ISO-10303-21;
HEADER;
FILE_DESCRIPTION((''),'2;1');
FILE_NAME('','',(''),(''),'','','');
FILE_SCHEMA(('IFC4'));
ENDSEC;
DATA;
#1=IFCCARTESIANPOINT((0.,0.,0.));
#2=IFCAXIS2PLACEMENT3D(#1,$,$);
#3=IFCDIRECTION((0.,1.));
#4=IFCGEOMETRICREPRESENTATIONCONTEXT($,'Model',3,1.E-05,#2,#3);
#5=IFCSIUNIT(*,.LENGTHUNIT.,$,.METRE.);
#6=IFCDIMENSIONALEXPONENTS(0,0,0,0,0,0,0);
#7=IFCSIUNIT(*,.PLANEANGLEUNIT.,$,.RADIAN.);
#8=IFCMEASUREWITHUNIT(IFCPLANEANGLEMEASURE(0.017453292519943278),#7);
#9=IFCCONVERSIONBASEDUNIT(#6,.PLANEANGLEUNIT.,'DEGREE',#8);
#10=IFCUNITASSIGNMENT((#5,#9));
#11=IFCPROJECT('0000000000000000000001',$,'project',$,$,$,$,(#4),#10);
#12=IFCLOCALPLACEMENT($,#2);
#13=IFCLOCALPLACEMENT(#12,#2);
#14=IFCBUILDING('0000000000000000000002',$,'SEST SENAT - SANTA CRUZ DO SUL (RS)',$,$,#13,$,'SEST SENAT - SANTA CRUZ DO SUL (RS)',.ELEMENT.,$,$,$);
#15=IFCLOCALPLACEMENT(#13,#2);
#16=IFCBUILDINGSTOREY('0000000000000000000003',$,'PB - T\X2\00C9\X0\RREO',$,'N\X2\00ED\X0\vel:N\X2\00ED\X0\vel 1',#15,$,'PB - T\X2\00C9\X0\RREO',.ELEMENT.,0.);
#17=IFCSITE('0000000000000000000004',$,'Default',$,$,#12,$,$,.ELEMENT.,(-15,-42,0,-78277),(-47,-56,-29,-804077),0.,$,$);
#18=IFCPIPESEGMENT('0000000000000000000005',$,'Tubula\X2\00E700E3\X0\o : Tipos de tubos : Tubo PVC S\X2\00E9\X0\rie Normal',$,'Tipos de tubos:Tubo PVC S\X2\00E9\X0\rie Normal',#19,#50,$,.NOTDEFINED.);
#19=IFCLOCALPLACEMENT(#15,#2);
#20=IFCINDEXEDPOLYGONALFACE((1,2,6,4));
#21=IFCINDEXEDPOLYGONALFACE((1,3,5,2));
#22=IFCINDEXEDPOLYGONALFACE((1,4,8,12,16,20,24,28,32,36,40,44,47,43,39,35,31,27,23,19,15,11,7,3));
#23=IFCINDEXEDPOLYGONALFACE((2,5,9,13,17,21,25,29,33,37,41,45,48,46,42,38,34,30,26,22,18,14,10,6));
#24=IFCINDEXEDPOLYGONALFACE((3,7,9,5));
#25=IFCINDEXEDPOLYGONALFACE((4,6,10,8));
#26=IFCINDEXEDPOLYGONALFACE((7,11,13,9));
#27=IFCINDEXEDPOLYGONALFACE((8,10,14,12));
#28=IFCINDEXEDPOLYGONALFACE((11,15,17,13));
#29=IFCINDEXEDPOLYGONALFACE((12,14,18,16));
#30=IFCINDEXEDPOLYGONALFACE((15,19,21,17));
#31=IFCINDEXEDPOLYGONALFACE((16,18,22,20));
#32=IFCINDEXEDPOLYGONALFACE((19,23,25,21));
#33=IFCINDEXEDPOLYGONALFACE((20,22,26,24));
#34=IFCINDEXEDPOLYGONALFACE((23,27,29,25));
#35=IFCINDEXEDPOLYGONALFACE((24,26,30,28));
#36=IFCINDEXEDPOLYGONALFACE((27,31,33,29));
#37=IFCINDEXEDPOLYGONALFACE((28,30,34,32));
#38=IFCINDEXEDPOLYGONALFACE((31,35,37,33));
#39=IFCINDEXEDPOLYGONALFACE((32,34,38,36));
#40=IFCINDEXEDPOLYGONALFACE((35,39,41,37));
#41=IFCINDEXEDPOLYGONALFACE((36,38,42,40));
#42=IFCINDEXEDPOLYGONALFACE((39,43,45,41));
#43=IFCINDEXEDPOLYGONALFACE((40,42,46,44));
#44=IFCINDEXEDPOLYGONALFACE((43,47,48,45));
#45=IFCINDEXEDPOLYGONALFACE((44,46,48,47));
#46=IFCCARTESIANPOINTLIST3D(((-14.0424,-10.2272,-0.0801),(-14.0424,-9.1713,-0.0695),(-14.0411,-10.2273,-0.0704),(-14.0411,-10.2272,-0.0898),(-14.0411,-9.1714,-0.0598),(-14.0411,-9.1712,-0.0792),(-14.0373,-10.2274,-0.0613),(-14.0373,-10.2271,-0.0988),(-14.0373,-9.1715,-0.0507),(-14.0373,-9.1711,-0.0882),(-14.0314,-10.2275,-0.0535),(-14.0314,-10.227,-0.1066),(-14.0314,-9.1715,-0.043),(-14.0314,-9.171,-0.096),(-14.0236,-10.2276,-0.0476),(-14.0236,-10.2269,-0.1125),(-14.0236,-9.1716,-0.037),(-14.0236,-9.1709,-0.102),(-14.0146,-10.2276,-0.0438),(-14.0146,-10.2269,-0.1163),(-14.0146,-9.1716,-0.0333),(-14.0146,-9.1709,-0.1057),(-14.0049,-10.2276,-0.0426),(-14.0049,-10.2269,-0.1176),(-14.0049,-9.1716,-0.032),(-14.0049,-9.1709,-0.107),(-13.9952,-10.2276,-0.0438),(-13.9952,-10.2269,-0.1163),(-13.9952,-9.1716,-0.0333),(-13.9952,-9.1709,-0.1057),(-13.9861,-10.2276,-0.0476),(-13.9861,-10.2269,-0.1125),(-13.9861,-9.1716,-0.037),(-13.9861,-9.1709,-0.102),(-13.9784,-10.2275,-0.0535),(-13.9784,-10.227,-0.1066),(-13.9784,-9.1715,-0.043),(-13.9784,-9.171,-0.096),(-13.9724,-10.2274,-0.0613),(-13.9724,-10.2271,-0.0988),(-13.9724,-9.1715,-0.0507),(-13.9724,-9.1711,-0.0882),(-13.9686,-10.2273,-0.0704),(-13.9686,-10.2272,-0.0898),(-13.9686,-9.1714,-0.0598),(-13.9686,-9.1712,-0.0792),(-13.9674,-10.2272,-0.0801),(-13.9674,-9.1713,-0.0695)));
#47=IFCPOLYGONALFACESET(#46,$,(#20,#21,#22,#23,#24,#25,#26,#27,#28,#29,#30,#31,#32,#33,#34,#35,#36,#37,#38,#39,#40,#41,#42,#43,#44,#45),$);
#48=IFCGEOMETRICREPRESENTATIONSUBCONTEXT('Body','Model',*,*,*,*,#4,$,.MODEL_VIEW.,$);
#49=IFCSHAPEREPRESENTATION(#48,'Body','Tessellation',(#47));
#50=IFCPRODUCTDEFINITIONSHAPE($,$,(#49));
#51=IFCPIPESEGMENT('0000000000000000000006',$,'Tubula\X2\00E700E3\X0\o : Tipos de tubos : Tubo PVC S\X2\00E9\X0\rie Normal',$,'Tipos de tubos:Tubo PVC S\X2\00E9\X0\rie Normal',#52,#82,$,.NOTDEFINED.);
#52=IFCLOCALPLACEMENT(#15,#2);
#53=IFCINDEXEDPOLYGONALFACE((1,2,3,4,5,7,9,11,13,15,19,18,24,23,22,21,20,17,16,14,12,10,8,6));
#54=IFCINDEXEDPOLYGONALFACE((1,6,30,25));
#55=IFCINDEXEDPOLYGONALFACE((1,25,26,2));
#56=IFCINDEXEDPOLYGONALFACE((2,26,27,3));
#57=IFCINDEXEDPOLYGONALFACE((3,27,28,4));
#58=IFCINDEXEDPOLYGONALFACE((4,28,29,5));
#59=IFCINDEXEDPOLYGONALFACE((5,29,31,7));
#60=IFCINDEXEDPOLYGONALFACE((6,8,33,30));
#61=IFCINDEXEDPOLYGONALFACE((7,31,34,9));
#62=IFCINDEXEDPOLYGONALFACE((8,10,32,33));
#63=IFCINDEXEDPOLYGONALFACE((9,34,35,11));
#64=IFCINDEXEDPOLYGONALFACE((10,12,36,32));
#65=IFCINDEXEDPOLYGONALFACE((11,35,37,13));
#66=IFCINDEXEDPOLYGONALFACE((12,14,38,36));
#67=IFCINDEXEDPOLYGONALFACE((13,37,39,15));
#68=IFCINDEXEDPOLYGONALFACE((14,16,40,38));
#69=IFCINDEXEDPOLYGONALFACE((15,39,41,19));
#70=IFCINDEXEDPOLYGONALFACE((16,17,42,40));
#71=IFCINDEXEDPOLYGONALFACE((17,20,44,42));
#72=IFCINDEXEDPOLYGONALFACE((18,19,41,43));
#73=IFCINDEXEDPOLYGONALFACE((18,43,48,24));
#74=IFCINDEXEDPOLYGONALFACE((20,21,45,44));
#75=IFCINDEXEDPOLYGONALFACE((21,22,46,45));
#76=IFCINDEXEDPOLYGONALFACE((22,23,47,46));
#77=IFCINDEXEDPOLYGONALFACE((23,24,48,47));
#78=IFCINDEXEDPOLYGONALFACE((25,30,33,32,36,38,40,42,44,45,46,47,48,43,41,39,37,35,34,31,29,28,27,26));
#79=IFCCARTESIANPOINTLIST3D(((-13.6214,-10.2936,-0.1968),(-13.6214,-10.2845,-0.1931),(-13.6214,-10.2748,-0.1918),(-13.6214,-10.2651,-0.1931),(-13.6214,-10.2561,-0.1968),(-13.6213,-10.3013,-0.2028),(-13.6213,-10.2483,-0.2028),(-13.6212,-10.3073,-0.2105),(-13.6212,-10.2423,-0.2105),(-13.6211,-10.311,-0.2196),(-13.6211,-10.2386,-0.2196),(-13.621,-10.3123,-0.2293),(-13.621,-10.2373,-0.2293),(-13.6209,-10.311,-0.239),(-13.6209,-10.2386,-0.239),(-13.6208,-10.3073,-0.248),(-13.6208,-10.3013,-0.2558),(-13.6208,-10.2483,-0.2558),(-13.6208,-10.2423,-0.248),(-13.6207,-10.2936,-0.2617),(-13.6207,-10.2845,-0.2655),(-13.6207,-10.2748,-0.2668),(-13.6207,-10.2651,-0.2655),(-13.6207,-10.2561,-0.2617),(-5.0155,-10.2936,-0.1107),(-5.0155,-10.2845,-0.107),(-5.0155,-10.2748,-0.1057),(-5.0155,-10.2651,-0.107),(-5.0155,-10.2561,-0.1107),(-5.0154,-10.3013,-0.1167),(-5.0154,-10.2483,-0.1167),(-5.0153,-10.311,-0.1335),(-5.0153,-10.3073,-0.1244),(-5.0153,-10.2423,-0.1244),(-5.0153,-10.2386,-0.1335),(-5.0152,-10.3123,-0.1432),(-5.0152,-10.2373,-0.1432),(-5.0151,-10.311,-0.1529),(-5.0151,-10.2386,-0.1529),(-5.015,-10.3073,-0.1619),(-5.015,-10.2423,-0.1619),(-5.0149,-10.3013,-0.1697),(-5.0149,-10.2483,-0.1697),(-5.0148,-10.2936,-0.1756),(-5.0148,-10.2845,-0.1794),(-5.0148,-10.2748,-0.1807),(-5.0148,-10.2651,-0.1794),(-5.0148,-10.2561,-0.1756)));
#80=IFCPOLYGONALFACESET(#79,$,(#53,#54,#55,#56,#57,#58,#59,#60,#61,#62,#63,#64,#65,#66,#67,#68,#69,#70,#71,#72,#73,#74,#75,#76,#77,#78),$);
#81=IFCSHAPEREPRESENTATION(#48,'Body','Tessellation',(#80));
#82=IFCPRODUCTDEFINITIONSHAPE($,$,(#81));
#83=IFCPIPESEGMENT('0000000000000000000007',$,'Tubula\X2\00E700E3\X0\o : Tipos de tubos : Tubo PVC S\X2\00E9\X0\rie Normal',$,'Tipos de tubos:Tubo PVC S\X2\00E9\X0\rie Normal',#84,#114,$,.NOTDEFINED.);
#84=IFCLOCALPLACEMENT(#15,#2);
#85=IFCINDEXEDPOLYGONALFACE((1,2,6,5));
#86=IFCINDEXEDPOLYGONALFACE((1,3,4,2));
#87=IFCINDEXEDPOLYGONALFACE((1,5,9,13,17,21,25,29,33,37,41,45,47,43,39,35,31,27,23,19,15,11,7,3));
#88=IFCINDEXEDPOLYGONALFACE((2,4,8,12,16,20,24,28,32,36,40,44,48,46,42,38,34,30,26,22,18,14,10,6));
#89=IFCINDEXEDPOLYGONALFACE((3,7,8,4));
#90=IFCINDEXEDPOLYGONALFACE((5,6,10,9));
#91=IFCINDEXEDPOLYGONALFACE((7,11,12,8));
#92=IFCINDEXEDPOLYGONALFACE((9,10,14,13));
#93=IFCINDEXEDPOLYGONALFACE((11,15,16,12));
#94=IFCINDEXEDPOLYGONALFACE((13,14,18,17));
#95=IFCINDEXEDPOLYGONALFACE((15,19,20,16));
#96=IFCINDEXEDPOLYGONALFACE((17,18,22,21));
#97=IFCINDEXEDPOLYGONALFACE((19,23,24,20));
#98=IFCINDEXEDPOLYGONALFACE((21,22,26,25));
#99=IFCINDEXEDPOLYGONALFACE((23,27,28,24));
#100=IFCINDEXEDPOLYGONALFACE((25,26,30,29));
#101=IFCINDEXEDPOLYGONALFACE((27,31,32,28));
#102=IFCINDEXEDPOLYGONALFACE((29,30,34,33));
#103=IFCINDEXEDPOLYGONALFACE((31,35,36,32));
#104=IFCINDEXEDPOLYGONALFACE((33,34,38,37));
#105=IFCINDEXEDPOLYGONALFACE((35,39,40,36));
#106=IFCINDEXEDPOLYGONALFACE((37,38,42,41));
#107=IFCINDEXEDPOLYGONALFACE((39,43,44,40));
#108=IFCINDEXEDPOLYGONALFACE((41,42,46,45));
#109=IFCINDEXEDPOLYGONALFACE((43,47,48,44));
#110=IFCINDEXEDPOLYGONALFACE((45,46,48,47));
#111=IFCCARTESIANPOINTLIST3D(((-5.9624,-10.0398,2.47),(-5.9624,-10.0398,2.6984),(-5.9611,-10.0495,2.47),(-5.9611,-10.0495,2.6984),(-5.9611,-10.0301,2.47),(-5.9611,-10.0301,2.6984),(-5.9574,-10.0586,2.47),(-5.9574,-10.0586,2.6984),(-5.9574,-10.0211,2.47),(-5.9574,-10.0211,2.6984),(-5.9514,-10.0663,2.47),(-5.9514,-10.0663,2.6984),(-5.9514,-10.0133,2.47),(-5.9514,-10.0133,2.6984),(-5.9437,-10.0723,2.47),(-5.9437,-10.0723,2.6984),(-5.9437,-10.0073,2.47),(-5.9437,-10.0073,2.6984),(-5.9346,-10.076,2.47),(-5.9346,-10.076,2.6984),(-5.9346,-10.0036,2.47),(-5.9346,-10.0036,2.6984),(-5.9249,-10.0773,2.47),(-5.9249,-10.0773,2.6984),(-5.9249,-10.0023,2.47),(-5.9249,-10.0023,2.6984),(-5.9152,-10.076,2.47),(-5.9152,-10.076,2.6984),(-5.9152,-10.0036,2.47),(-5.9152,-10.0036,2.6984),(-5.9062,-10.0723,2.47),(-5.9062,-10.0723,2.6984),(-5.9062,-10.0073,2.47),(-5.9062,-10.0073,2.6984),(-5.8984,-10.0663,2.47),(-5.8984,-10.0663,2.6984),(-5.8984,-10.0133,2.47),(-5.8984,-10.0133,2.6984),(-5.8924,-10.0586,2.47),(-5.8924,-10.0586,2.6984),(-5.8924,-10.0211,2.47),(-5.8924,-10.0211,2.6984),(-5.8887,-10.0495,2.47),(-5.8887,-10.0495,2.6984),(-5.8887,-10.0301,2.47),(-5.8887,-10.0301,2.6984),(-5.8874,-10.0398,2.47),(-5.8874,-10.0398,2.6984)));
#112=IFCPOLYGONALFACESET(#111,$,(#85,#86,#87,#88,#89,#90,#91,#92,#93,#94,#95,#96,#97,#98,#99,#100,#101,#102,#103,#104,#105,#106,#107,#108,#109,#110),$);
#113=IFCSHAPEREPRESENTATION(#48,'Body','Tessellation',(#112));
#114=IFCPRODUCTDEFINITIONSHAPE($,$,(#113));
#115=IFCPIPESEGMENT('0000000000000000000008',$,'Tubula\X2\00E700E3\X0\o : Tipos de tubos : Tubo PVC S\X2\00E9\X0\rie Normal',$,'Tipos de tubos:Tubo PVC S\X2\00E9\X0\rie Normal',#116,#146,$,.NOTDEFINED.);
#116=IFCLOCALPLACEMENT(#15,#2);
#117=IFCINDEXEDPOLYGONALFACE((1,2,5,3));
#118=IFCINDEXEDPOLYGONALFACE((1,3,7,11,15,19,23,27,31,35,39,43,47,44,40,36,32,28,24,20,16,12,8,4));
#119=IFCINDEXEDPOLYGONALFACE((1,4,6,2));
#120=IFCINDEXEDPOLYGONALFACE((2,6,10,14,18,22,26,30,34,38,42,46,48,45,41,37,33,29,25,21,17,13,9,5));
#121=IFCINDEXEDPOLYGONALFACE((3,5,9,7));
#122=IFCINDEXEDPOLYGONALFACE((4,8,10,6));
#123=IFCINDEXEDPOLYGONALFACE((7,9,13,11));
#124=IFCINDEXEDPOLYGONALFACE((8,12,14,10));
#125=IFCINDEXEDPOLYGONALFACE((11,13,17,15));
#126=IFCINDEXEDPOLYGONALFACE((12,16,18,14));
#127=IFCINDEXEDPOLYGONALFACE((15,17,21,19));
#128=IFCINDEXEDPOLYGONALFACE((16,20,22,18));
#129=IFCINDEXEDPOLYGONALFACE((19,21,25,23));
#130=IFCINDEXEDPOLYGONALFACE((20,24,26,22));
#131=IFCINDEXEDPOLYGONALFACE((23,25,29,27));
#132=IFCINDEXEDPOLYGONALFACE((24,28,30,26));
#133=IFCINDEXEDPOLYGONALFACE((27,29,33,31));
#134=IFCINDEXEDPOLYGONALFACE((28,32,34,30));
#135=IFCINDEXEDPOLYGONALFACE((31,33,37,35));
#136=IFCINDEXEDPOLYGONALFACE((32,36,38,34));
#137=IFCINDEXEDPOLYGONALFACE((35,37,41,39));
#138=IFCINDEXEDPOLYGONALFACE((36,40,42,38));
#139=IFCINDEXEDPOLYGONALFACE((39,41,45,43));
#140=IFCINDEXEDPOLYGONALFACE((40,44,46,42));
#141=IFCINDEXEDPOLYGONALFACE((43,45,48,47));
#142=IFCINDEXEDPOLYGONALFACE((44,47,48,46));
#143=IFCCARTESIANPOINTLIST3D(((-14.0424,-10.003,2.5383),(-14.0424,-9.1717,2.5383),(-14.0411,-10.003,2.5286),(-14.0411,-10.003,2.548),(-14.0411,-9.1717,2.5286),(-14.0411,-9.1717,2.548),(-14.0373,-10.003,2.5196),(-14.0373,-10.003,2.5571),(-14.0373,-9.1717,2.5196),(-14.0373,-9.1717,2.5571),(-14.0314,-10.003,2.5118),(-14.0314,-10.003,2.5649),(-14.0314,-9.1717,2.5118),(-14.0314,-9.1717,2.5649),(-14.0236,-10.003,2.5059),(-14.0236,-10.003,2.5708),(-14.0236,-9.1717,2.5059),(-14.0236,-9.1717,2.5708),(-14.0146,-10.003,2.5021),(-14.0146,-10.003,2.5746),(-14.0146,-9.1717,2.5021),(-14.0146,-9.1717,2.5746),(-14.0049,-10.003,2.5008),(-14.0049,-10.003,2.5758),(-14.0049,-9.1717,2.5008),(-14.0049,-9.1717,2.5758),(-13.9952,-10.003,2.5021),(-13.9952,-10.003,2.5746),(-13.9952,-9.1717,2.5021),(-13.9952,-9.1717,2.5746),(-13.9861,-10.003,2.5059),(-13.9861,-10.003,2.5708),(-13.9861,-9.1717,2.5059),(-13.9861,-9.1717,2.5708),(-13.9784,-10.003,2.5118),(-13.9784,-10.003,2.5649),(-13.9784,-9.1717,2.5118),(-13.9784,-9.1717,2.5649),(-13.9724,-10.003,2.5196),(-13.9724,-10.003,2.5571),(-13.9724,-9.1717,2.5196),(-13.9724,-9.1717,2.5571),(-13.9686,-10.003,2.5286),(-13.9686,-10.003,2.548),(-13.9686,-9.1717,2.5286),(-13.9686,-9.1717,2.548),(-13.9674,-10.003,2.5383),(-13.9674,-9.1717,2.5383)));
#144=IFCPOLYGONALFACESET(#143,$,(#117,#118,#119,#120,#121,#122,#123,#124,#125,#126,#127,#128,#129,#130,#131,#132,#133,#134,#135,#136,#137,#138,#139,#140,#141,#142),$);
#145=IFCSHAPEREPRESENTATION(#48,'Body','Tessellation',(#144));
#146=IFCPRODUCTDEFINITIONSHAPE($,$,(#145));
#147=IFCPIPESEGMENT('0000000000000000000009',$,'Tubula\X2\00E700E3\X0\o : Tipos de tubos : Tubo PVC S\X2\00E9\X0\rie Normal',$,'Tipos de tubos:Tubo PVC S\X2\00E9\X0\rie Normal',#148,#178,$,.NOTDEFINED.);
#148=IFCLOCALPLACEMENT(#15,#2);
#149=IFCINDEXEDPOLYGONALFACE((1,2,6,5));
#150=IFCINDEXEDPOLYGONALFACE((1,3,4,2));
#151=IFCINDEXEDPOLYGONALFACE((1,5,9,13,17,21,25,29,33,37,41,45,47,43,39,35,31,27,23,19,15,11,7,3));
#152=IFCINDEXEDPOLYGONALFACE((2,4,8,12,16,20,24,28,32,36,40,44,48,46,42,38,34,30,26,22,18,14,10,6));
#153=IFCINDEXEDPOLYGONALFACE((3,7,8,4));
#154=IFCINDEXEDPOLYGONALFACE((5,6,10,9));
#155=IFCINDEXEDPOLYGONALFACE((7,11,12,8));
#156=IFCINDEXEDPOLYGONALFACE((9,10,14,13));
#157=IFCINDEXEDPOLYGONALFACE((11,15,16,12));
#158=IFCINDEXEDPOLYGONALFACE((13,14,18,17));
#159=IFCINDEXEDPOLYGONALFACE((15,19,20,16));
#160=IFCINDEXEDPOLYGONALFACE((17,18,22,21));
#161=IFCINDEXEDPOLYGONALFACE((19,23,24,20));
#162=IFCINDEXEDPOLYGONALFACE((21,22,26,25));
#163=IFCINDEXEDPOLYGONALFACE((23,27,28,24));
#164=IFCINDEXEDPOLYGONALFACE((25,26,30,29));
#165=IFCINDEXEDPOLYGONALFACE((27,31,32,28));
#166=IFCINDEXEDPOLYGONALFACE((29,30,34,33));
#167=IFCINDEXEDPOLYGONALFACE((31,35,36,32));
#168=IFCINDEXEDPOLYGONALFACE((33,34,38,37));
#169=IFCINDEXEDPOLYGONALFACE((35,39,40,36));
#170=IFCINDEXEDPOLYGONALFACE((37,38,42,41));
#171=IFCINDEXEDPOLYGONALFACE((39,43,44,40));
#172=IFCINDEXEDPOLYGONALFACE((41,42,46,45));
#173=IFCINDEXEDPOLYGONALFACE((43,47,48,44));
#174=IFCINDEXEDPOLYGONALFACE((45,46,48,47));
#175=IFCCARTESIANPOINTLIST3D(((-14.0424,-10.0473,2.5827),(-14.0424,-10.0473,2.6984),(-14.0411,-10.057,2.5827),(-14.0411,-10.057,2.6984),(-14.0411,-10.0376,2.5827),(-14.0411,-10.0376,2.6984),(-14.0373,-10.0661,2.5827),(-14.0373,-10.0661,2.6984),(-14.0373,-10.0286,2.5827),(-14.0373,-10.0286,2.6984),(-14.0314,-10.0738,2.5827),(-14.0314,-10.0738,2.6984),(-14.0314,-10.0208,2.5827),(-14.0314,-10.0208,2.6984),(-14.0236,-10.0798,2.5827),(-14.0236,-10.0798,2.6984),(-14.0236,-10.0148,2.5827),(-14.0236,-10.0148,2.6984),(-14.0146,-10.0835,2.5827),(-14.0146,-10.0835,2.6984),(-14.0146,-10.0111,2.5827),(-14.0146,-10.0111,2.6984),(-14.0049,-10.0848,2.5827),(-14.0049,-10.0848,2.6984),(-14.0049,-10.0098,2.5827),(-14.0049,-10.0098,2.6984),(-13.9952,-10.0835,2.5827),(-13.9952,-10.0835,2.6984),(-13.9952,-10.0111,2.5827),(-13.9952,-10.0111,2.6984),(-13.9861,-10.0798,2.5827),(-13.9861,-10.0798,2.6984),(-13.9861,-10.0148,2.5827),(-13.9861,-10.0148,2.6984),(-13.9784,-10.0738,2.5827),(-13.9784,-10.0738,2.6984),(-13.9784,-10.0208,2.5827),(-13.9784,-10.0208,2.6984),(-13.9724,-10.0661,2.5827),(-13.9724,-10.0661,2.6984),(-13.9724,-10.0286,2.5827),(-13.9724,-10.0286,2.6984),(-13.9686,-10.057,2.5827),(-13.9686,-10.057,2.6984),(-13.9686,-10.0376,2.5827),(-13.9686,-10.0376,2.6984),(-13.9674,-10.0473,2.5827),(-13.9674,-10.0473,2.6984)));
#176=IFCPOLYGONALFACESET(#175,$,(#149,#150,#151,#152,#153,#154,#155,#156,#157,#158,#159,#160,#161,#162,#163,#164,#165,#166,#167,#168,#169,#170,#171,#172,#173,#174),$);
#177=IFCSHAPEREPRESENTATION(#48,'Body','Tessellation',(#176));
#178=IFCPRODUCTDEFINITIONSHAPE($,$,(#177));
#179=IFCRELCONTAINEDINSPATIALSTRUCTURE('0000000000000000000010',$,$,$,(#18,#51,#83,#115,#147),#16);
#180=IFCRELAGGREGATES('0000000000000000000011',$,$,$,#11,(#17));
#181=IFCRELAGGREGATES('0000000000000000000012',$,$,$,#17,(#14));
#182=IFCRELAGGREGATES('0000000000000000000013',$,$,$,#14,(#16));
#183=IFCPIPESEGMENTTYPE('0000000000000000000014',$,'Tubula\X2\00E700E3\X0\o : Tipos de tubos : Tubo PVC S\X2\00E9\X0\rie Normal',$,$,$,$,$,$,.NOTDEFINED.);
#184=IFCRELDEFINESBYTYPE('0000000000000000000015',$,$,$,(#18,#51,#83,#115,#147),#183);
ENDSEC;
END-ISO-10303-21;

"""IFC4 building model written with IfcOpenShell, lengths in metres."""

from ifc_helpers import new_model, entity, si_unit, converted_unit, direction, frame, origin, place, context, subcontext, project, spatial, arc, indexed_curve, outline, extrude, type_object, element, save


model = new_model("IFC4")

# Units and contexts
model_context = context("Model", 3, precision=1e-05, world=origin(), true_north=direction((0.0, 1.0)))
body_context = subcontext(model_context, "Body", "Model", "MODEL_VIEW")
ifc_project = project(units=[si_unit("LENGTHUNIT", "METRE"), converted_unit("PLANEANGLEUNIT", "DEGREE", entity("IfcPlaneAngleMeasure", 0.017453292519943278), si_unit("PLANEANGLEUNIT", "RADIAN"), dimensions=[0, 0, 0, 0, 0, 0, 0])], contexts=[model_context])

# Site, building, storey
site_placement = place(None, origin())
site = spatial("IfcSite", under=ifc_project, at=site_placement, Name="Default", CompositionType="ELEMENT", RefLatitude=(-15, -42, 0, -78277), RefLongitude=(-47, -56, -29, -804077), RefElevation=0.0)
building_placement = place(site_placement, origin())
building = spatial("IfcBuilding", under=site, at=building_placement, Name="SEST SENAT - SANTA CRUZ DO SUL (RS)", LongName="SEST SENAT - SANTA CRUZ DO SUL (RS)", CompositionType="ELEMENT")
storey_placement = place(building_placement, origin())
storey = spatial("IfcBuildingStorey", under=building, at=storey_placement, Name="PB - TÉRREO", ObjectType="Nível:Nível 1", LongName="PB - TÉRREO", CompositionType="ELEMENT", Elevation=0.0)

# Pipe segments
pipe_segment_type_1 = type_object("IfcPipeSegmentType", Name="Tubulação : Tipos de tubos : Tubo PVC Série Normal", PredefinedType="NOTDEFINED")
pipe_segment_1_placement = place(storey_placement, frame((-14.044, -10.2292, -0.1192)))
element("IfcPipeSegment", 1, at=pipe_segment_1_placement, inside=storey, type_object=pipe_segment_type_1, Name="Tubulação : Tipos de tubos : Tubo PVC Série Normal", ObjectType="Tipos de tubos:Tubo PVC Série Normal", PredefinedType="NOTDEFINED", context=body_context, shape_type="SweptSolid", body=[
    extrude(outline(indexed_curve([(0.0375, 0.0), (0.0265, 0.0265), (0.0, 0.0375), (-0.0265, 0.0265), (-0.0375, 0.0), (-0.0265, -0.0265), (0.0, -0.0375), (0.0265, -0.0265)], segments=[arc(1, 2, 3), arc(3, 4, 5), arc(5, 6, 7), arc(7, 8, 1)], self_intersect=False)), frame((0.0391, 0.002, 0.0391), z_axis=(0.0, 0.99995, 0.01), x_axis=(-1.0, 0.0, 0.0)), (0.0, 0.0, 1.0), 1.056),
])
pipe_segment_2_placement = place(storey_placement, frame((-13.623, -10.3139, -0.2684)))
element("IfcPipeSegment", 2, at=pipe_segment_2_placement, inside=storey, type_object=pipe_segment_type_1, Name="Tubulação : Tipos de tubos : Tubo PVC Série Normal", ObjectType="Tipos de tubos:Tubo PVC Série Normal", PredefinedType="NOTDEFINED", context=body_context, shape_type="SweptSolid", body=[
    extrude(outline(indexed_curve([(0.0375, 0.0), (0.0265, 0.0265), (0.0, 0.0375), (-0.0265, 0.0265), (-0.0375, 0.0), (-0.0265, -0.0265), (0.0, -0.0375), (0.0265, -0.0265)], segments=[arc(1, 2, 3), arc(3, 4, 5), arc(5, 6, 7), arc(7, 8, 1)], self_intersect=False)), frame((0.002, 0.0391, 0.0391), z_axis=(0.99995, 0.0, 0.010005), x_axis=(0.0, 1.0, 0.0)), (0.0, 0.0, 1.0), 8.6063),
])
pipe_segment_3_placement = place(storey_placement, frame((-5.964, -10.0789, 2.47)))
element("IfcPipeSegment", 3, at=pipe_segment_3_placement, inside=storey, type_object=pipe_segment_type_1, Name="Tubulação : Tipos de tubos : Tubo PVC Série Normal", ObjectType="Tipos de tubos:Tubo PVC Série Normal", PredefinedType="NOTDEFINED", context=body_context, shape_type="SweptSolid", body=[
    extrude(outline(indexed_curve([(0.0375, 0.0), (0.0265, 0.0265), (0.0, 0.0375), (-0.0265, 0.0265), (-0.0375, 0.0), (-0.0265, -0.0265), (0.0, -0.0375), (0.0265, -0.0265)], segments=[arc(1, 2, 3), arc(3, 4, 5), arc(5, 6, 7), arc(7, 8, 1)], self_intersect=False)), frame((0.0391, 0.0391, 0.0), z_axis=(0.0, 0.0, 1.0), x_axis=(-1.0, 0.0, 0.0)), (0.0, 0.0, 1.0), 0.2283),
])
pipe_segment_4_placement = place(storey_placement, frame((-14.044, -10.003, 2.5774)))
element("IfcPipeSegment", 4, at=pipe_segment_4_placement, inside=storey, type_object=pipe_segment_type_1, Name="Tubulação : Tipos de tubos : Tubo PVC Série Normal", ObjectType="Tipos de tubos:Tubo PVC Série Normal", PredefinedType="NOTDEFINED", context=body_context, shape_type="SweptSolid", body=[
    extrude(outline(indexed_curve([(0.0375, 0.0), (0.0265, 0.0265), (0.0, 0.0375), (-0.0265, 0.0265), (-0.0375, 0.0), (-0.0265, -0.0265), (0.0, -0.0375), (0.0265, -0.0265)], segments=[arc(1, 2, 3), arc(3, 4, 5), arc(5, 6, 7), arc(7, 8, 1)], self_intersect=False)), frame((0.0391, 0.0, -0.0391), z_axis=(0.0, 1.0, 0.0), x_axis=(-1.0, 0.0, 0.0)), (0.0, 0.0, 1.0), 0.8313),
])
pipe_segment_5_placement = place(storey_placement, frame((-14.044, -10.0864, 2.5827)))
element("IfcPipeSegment", 5, at=pipe_segment_5_placement, inside=storey, type_object=pipe_segment_type_1, Name="Tubulação : Tipos de tubos : Tubo PVC Série Normal", ObjectType="Tipos de tubos:Tubo PVC Série Normal", PredefinedType="NOTDEFINED", context=body_context, shape_type="SweptSolid", body=[
    extrude(outline(indexed_curve([(0.0375, 0.0), (0.0265, 0.0265), (0.0, 0.0375), (-0.0265, 0.0265), (-0.0375, 0.0), (-0.0265, -0.0265), (0.0, -0.0375), (0.0265, -0.0265)], segments=[arc(1, 2, 3), arc(3, 4, 5), arc(5, 6, 7), arc(7, 8, 1)], self_intersect=False)), frame((0.0391, 0.0391, 0.0), z_axis=(0.0, 0.0, 1.0), x_axis=(-1.0, 0.0, 0.0)), (0.0, 0.0, 1.0), 0.1157),
])

save(model, "model.ifc")
